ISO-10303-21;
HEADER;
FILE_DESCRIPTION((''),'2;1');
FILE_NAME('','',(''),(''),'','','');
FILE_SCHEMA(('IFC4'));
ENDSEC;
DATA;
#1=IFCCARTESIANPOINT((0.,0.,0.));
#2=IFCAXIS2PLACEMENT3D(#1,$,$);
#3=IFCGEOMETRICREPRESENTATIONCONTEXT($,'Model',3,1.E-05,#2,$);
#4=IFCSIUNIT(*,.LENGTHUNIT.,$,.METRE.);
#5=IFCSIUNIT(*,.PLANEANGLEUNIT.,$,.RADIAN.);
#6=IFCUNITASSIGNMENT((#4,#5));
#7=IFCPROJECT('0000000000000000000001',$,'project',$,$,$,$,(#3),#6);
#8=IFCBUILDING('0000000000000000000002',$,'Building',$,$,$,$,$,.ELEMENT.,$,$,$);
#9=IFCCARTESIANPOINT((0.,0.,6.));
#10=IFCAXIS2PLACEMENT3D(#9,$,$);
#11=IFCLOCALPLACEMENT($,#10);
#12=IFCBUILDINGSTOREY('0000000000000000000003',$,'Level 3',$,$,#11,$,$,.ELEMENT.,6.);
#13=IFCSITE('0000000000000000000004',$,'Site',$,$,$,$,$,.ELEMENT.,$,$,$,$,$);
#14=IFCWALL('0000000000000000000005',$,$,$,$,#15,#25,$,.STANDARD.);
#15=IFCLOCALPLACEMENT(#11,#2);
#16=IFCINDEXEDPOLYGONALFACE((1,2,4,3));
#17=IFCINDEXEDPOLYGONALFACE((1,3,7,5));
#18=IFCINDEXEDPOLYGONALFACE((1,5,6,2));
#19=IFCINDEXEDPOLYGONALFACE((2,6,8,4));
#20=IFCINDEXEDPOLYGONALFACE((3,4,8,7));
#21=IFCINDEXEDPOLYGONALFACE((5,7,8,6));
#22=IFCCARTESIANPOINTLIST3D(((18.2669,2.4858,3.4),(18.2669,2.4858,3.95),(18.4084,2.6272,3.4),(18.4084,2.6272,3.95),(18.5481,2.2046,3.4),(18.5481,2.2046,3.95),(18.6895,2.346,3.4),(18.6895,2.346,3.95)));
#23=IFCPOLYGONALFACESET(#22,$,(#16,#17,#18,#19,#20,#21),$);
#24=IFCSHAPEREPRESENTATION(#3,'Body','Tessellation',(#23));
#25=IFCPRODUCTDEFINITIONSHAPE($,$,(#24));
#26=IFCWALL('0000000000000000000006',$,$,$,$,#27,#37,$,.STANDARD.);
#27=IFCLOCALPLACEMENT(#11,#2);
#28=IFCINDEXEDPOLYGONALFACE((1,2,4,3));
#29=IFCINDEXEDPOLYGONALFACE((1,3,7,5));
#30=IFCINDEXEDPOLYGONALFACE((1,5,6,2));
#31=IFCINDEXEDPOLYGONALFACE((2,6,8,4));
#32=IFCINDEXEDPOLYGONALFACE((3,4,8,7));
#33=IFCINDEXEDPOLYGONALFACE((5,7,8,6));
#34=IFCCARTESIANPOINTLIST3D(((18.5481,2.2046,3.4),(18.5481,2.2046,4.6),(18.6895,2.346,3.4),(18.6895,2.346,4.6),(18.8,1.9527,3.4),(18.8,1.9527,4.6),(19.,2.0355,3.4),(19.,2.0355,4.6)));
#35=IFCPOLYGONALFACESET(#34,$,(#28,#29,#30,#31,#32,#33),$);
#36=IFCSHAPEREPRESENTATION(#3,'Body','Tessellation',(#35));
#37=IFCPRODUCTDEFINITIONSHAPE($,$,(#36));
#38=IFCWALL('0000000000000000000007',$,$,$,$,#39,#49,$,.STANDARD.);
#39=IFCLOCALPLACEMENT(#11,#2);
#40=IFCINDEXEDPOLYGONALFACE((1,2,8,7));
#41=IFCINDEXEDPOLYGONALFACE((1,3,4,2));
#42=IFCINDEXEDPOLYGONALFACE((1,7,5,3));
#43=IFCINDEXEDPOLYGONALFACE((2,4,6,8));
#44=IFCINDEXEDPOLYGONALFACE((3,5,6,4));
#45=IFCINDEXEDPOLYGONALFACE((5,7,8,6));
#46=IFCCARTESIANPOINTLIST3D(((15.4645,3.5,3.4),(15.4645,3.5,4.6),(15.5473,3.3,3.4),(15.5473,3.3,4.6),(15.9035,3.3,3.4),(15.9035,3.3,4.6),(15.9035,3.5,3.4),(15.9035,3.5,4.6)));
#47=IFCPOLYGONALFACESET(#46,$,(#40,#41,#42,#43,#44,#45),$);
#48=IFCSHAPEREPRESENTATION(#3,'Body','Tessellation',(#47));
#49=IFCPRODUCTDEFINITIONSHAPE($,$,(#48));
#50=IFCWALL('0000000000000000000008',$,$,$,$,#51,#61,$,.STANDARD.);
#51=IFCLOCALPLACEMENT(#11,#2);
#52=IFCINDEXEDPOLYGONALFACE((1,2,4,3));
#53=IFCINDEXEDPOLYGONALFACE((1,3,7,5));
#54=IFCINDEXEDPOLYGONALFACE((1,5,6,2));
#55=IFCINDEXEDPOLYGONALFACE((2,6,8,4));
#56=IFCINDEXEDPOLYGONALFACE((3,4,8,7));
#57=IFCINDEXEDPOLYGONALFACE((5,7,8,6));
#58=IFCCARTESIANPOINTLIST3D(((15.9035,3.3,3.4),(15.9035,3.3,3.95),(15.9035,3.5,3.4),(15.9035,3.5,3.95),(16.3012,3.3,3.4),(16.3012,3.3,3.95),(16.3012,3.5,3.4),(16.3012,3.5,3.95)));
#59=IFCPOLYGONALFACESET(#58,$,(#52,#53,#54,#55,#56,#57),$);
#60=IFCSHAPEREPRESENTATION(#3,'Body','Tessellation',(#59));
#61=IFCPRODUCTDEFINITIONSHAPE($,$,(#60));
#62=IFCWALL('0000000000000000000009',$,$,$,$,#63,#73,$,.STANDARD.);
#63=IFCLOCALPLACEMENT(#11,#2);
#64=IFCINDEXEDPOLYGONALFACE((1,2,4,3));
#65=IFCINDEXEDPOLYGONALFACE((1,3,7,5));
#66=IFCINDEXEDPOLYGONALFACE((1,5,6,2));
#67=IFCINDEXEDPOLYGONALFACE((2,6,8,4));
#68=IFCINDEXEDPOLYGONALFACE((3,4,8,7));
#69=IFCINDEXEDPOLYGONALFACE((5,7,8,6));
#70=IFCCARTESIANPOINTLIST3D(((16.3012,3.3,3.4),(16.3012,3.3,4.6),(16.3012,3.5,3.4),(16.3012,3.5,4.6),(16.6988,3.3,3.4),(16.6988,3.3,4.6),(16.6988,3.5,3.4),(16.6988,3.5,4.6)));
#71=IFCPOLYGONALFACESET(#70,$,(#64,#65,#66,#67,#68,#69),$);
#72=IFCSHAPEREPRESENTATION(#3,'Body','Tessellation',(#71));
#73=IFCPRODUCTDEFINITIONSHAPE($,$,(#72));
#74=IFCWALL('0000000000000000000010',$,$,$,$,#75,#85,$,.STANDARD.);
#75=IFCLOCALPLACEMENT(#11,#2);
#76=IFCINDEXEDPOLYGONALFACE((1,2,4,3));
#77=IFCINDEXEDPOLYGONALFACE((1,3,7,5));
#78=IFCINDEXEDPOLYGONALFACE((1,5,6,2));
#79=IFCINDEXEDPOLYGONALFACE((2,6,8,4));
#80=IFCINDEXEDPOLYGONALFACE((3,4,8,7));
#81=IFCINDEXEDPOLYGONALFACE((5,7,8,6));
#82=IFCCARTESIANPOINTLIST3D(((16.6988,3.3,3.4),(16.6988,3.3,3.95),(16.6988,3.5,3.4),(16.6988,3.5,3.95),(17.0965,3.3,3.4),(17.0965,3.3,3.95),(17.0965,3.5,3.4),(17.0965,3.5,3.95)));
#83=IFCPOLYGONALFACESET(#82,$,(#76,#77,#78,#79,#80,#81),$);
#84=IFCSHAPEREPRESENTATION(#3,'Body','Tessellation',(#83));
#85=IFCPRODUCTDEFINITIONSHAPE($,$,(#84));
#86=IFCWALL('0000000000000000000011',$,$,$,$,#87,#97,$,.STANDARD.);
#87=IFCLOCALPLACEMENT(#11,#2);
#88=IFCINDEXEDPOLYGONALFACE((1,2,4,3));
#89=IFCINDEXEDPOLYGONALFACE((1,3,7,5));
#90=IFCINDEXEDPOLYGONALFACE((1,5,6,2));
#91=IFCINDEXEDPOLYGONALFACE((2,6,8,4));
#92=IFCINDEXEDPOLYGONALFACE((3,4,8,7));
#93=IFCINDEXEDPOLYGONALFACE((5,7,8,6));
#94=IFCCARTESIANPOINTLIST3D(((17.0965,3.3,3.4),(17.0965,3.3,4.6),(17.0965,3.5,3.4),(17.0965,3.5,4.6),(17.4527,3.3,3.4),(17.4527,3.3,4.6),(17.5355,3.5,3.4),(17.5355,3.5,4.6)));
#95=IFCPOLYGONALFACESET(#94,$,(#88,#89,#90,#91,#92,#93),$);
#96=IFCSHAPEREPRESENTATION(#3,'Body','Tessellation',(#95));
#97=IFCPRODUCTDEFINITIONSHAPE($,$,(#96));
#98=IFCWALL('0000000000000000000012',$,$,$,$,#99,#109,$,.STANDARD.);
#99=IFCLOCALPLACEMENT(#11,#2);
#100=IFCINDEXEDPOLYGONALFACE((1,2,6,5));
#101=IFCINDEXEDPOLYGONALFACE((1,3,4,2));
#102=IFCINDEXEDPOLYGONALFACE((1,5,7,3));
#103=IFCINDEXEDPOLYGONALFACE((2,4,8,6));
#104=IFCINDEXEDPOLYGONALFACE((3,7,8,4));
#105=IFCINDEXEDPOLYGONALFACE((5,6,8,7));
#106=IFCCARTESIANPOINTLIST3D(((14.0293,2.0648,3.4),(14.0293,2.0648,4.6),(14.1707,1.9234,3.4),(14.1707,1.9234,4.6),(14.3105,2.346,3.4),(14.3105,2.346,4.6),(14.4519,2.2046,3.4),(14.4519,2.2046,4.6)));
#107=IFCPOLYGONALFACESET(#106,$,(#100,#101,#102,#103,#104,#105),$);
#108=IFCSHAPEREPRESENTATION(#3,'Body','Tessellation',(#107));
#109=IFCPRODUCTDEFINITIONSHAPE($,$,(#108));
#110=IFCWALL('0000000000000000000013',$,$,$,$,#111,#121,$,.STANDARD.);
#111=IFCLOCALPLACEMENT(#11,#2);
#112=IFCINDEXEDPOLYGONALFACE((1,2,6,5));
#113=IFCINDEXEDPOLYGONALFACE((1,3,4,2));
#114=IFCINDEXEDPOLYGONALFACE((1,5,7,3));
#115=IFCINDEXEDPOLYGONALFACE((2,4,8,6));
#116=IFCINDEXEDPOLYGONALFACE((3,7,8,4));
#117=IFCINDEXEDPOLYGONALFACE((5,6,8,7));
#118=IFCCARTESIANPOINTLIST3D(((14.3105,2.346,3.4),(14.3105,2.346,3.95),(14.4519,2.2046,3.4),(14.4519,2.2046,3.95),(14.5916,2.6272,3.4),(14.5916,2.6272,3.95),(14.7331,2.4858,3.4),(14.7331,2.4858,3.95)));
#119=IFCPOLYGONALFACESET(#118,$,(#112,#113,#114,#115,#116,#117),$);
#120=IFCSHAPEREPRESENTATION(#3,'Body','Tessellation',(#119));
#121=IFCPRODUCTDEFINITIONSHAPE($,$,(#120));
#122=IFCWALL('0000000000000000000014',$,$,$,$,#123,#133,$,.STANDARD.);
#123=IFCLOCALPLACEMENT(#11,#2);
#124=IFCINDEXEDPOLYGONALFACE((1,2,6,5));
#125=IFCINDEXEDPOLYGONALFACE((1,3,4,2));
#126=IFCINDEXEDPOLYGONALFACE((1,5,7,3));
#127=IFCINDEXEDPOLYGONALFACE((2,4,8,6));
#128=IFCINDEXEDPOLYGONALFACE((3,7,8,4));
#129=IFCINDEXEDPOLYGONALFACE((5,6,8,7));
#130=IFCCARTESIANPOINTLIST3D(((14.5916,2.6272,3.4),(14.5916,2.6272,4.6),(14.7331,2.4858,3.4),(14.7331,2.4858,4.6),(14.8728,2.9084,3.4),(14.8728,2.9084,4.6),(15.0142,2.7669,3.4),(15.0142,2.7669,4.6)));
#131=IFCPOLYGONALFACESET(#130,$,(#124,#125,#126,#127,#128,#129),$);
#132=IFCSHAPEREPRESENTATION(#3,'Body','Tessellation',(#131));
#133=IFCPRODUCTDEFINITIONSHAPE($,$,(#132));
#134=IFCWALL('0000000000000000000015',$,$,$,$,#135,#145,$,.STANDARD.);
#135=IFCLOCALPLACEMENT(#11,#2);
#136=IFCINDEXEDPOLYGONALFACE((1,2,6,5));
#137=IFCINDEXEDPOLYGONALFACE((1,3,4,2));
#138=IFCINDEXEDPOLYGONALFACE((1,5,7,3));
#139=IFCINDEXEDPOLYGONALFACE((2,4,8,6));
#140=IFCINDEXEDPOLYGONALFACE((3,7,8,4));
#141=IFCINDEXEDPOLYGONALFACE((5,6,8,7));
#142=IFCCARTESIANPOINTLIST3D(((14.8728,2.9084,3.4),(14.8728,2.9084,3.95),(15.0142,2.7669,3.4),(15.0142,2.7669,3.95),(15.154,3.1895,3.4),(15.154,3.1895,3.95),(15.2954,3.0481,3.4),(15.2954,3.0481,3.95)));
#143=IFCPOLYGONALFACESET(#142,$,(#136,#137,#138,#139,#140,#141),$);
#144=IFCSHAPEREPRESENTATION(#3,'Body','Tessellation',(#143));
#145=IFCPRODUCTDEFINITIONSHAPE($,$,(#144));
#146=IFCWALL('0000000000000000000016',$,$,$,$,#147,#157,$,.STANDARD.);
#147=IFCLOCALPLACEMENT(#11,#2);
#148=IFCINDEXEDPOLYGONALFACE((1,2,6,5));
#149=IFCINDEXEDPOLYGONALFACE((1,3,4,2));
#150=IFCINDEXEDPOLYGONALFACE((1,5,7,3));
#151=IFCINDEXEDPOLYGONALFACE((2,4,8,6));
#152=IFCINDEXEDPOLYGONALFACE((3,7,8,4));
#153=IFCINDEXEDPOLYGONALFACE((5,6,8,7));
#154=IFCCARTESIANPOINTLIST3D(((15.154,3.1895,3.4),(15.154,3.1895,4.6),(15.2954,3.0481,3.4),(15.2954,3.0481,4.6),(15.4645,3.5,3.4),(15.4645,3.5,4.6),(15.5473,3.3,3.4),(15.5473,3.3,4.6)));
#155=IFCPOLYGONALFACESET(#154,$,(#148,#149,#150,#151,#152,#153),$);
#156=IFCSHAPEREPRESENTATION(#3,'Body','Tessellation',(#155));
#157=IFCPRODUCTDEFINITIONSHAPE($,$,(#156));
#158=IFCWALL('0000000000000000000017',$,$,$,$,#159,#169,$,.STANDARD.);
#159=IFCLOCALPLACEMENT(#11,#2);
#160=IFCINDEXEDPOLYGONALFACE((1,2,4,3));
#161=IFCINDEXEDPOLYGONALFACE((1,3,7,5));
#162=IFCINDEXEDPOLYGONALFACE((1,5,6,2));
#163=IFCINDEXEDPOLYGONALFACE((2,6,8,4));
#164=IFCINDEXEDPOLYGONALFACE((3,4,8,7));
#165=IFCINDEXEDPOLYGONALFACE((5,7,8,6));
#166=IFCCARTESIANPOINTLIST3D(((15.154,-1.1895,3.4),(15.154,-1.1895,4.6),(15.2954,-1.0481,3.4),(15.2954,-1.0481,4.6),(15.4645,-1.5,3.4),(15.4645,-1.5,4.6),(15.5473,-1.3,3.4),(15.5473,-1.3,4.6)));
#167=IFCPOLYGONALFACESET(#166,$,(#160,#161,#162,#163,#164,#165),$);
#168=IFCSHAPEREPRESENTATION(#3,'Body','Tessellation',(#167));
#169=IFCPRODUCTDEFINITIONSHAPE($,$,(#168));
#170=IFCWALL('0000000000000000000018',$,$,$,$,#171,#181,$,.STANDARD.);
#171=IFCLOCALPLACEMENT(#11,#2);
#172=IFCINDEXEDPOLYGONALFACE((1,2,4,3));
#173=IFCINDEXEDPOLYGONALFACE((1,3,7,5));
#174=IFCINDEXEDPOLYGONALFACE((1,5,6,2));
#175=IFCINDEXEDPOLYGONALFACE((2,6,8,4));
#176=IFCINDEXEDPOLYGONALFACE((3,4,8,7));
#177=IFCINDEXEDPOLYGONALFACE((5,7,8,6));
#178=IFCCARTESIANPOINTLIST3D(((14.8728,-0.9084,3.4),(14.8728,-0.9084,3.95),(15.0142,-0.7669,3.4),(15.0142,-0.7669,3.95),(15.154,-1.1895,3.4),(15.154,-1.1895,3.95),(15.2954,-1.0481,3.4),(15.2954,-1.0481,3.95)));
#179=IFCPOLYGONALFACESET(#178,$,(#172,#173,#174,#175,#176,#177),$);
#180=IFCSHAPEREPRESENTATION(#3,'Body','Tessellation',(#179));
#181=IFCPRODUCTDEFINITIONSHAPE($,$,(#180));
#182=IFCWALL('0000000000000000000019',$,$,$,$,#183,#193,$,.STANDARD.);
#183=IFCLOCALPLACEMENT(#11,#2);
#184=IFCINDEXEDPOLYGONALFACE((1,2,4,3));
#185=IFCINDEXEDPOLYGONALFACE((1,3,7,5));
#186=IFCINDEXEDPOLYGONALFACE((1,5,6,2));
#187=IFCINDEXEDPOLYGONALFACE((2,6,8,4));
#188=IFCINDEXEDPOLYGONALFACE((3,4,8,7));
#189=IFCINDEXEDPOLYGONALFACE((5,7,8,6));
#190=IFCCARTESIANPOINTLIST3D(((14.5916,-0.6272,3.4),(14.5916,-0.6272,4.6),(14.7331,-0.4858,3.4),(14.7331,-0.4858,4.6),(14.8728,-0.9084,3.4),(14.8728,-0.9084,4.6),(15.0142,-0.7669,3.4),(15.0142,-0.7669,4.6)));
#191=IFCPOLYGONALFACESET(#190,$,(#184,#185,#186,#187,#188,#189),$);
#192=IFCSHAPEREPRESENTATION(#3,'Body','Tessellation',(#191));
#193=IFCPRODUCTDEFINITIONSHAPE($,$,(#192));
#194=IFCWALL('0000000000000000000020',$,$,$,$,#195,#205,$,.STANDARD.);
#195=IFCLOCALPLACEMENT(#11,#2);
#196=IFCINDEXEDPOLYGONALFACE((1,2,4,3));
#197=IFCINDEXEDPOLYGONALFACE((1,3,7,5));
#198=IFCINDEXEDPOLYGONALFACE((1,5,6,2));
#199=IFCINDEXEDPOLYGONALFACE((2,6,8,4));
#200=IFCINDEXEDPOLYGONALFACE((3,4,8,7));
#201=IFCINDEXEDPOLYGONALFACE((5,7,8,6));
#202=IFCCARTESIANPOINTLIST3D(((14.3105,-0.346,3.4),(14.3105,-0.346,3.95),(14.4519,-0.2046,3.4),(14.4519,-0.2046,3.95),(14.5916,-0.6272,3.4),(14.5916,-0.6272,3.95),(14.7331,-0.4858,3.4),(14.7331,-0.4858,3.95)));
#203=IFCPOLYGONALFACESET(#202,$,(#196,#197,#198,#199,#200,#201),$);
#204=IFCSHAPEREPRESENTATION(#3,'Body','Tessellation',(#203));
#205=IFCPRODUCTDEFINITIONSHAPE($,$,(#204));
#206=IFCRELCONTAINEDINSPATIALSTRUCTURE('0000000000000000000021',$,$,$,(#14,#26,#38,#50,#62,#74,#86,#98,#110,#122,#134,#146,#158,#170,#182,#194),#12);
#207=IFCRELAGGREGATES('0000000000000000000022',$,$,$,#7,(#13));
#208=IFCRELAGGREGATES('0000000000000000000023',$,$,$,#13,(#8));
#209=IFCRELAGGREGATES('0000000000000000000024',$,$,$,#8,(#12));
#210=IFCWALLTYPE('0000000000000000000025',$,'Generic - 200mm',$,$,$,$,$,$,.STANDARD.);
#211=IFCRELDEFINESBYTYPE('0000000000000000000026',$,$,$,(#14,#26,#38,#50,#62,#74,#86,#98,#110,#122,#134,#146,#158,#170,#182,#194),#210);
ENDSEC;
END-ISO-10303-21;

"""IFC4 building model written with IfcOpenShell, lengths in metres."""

from ifc_helpers import new_model, si_unit, frame, frame_2d, origin, place, context, project, spatial, polyline, rectangle, outline, extrude, type_object, element, save


model = new_model("IFC4")

# Units and contexts
model_context = context("Model", 3, precision=1e-05, world=origin())
ifc_project = project(units=[si_unit("LENGTHUNIT", "METRE"), si_unit("PLANEANGLEUNIT", "RADIAN")], contexts=[model_context])

# Site, building, storey
site = spatial("IfcSite", under=ifc_project, Name="Site", CompositionType="ELEMENT")
building = spatial("IfcBuilding", under=site, Name="Building", CompositionType="ELEMENT")
storey_placement = place(None, frame((0.0, 0.0, 6.0)))
storey = spatial("IfcBuildingStorey", under=building, at=storey_placement, Name="Level 3", CompositionType="ELEMENT", Elevation=6.0)

# Walls
wall_type = type_object("IfcWallType", Name="Generic - 200mm", PredefinedType="STANDARD")
wall_1_placement = place(None, frame((18.3376, 2.5565, 9.4), z_axis=(0.0, 0.0, 1.0), x_axis=(0.707107, -0.707107, 0.0)))
element("IfcWall", 1, at=wall_1_placement, inside=storey, type_object=wall_type, PredefinedType="STANDARD", context=model_context, shape_type="SweptSolid", body=[
    extrude(rectangle(XDim=0.3976, YDim=0.2, at=frame_2d((0.1988, 0.0))), origin(), (0.0, 0.0, 1.0), 0.55),
])
wall_2_placement = place(None, frame((18.6188, 2.2753, 9.4), z_axis=(0.0, 0.0, 1.0), x_axis=(0.707107, -0.707107, 0.0)))
element("IfcWall", 2, at=wall_2_placement, inside=storey, type_object=wall_type, PredefinedType="STANDARD", context=model_context, shape_type="SweptSolid", body=[
    extrude(outline(polyline([(0.0, -0.1), (0.3562, -0.1), (0.4391, 0.1), (0.0, 0.1), (0.0, -0.1)])), origin(), (0.0, 0.0, 1.0), 1.2),
])
wall_3_placement = place(None, frame((15.5059, 3.4, 9.4), z_axis=(0.0, 0.0, 1.0), x_axis=(1.0, 0.0, 0.0)))
element("IfcWall", 3, at=wall_3_placement, inside=storey, type_object=wall_type, PredefinedType="STANDARD", context=model_context, shape_type="SweptSolid", body=[
    extrude(outline(polyline([(0.0414, -0.1), (0.3976, -0.1), (0.3976, 0.1), (-0.0414, 0.1), (0.0414, -0.1)])), origin(), (0.0, 0.0, 1.0), 1.2),
])
wall_4_placement = place(None, frame((15.9035, 3.4, 9.4), z_axis=(0.0, 0.0, 1.0), x_axis=(1.0, 0.0, 0.0)))
element("IfcWall", 4, at=wall_4_placement, inside=storey, type_object=wall_type, PredefinedType="STANDARD", context=model_context, shape_type="SweptSolid", body=[
    extrude(rectangle(XDim=0.3976, YDim=0.2, at=frame_2d((0.1988, 0.0))), origin(), (0.0, 0.0, 1.0), 0.55),
])
wall_5_placement = place(None, frame((16.3012, 3.4, 9.4), z_axis=(0.0, 0.0, 1.0), x_axis=(1.0, 0.0, 0.0)))
element("IfcWall", 5, at=wall_5_placement, inside=storey, type_object=wall_type, PredefinedType="STANDARD", context=model_context, shape_type="SweptSolid", body=[
    extrude(rectangle(XDim=0.3976, YDim=0.2, at=frame_2d((0.1988, 0.0))), origin(), (0.0, 0.0, 1.0), 1.2),
])
wall_6_placement = place(None, frame((16.6988, 3.4, 9.4), z_axis=(0.0, 0.0, 1.0), x_axis=(1.0, 0.0, 0.0)))
element("IfcWall", 6, at=wall_6_placement, inside=storey, type_object=wall_type, PredefinedType="STANDARD", context=model_context, shape_type="SweptSolid", body=[
    extrude(rectangle(XDim=0.3976, YDim=0.2, at=frame_2d((0.1988, 0.0))), origin(), (0.0, 0.0, 1.0), 0.55),
])
wall_7_placement = place(None, frame((17.0965, 3.4, 9.4), z_axis=(0.0, 0.0, 1.0), x_axis=(1.0, 0.0, 0.0)))
element("IfcWall", 7, at=wall_7_placement, inside=storey, type_object=wall_type, PredefinedType="STANDARD", context=model_context, shape_type="SweptSolid", body=[
    extrude(outline(polyline([(0.0, -0.1), (0.3562, -0.1), (0.4391, 0.1), (0.0, 0.1), (0.0, -0.1)])), origin(), (0.0, 0.0, 1.0), 1.2),
])
wall_8_placement = place(None, frame((14.1, 1.9941, 9.4), z_axis=(0.0, 0.0, 1.0), x_axis=(0.707107, 0.707107, 0.0)))
element("IfcWall", 8, at=wall_8_placement, inside=storey, type_object=wall_type, PredefinedType="STANDARD", context=model_context, shape_type="SweptSolid", body=[
    extrude(rectangle(XDim=0.3976, YDim=0.2, at=frame_2d((0.1988, 0.0))), origin(), (0.0, 0.0, 1.0), 1.2),
])
wall_9_placement = place(None, frame((14.3812, 2.2753, 9.4), z_axis=(0.0, 0.0, 1.0), x_axis=(0.707107, 0.707107, 0.0)))
element("IfcWall", 9, at=wall_9_placement, inside=storey, type_object=wall_type, PredefinedType="STANDARD", context=model_context, shape_type="SweptSolid", body=[
    extrude(rectangle(XDim=0.3976, YDim=0.2, at=frame_2d((0.1988, 0.0))), origin(), (0.0, 0.0, 1.0), 0.55),
])
wall_10_placement = place(None, frame((14.6624, 2.5565, 9.4), z_axis=(0.0, 0.0, 1.0), x_axis=(0.707107, 0.707107, 0.0)))
element("IfcWall", 10, at=wall_10_placement, inside=storey, type_object=wall_type, PredefinedType="STANDARD", context=model_context, shape_type="SweptSolid", body=[
    extrude(rectangle(XDim=0.3976, YDim=0.2, at=frame_2d((0.1988, 0.0))), origin(), (0.0, 0.0, 1.0), 1.2),
])
wall_11_placement = place(None, frame((14.9435, 2.8376, 9.4), z_axis=(0.0, 0.0, 1.0), x_axis=(0.707107, 0.707107, 0.0)))
element("IfcWall", 11, at=wall_11_placement, inside=storey, type_object=wall_type, PredefinedType="STANDARD", context=model_context, shape_type="SweptSolid", body=[
    extrude(rectangle(XDim=0.3976, YDim=0.2, at=frame_2d((0.1988, 0.0))), origin(), (0.0, 0.0, 1.0), 0.55),
])
wall_12_placement = place(None, frame((15.2247, 3.1188, 9.4), z_axis=(0.0, 0.0, 1.0), x_axis=(0.707107, 0.707107, 0.0)))
element("IfcWall", 12, at=wall_12_placement, inside=storey, type_object=wall_type, PredefinedType="STANDARD", context=model_context, shape_type="SweptSolid", body=[
    extrude(outline(polyline([(0.0, -0.1), (0.3562, -0.1), (0.4391, 0.1), (0.0, 0.1), (0.0, -0.1)])), origin(), (0.0, 0.0, 1.0), 1.2),
])
wall_13_placement = place(None, frame((15.5059, -1.4, 9.4), z_axis=(0.0, 0.0, 1.0), x_axis=(-0.707107, 0.707107, 0.0)))
element("IfcWall", 13, at=wall_13_placement, inside=storey, type_object=wall_type, PredefinedType="STANDARD", context=model_context, shape_type="SweptSolid", body=[
    extrude(outline(polyline([(0.0414, -0.1), (0.3976, -0.1), (0.3976, 0.1), (-0.0414, 0.1), (0.0414, -0.1)])), origin(), (0.0, 0.0, 1.0), 1.2),
])
wall_14_placement = place(None, frame((15.2247, -1.1188, 9.4), z_axis=(0.0, 0.0, 1.0), x_axis=(-0.707107, 0.707107, 0.0)))
element("IfcWall", 14, at=wall_14_placement, inside=storey, type_object=wall_type, PredefinedType="STANDARD", context=model_context, shape_type="SweptSolid", body=[
    extrude(rectangle(XDim=0.3976, YDim=0.2, at=frame_2d((0.1988, 0.0))), origin(), (0.0, 0.0, 1.0), 0.55),
])
wall_15_placement = place(None, frame((14.9435, -0.8376, 9.4), z_axis=(0.0, 0.0, 1.0), x_axis=(-0.707107, 0.707107, 0.0)))
element("IfcWall", 15, at=wall_15_placement, inside=storey, type_object=wall_type, PredefinedType="STANDARD", context=model_context, shape_type="SweptSolid", body=[
    extrude(rectangle(XDim=0.3976, YDim=0.2, at=frame_2d((0.1988, 0.0))), origin(), (0.0, 0.0, 1.0), 1.2),
])
wall_16_placement = place(None, frame((14.6624, -0.5565, 9.4), z_axis=(0.0, 0.0, 1.0), x_axis=(-0.707107, 0.707107, 0.0)))
element("IfcWall", 16, at=wall_16_placement, inside=storey, type_object=wall_type, PredefinedType="STANDARD", context=model_context, shape_type="SweptSolid", body=[
    extrude(rectangle(XDim=0.3976, YDim=0.2, at=frame_2d((0.1988, 0.0))), origin(), (0.0, 0.0, 1.0), 0.55),
])

save(model, "model.ifc")
